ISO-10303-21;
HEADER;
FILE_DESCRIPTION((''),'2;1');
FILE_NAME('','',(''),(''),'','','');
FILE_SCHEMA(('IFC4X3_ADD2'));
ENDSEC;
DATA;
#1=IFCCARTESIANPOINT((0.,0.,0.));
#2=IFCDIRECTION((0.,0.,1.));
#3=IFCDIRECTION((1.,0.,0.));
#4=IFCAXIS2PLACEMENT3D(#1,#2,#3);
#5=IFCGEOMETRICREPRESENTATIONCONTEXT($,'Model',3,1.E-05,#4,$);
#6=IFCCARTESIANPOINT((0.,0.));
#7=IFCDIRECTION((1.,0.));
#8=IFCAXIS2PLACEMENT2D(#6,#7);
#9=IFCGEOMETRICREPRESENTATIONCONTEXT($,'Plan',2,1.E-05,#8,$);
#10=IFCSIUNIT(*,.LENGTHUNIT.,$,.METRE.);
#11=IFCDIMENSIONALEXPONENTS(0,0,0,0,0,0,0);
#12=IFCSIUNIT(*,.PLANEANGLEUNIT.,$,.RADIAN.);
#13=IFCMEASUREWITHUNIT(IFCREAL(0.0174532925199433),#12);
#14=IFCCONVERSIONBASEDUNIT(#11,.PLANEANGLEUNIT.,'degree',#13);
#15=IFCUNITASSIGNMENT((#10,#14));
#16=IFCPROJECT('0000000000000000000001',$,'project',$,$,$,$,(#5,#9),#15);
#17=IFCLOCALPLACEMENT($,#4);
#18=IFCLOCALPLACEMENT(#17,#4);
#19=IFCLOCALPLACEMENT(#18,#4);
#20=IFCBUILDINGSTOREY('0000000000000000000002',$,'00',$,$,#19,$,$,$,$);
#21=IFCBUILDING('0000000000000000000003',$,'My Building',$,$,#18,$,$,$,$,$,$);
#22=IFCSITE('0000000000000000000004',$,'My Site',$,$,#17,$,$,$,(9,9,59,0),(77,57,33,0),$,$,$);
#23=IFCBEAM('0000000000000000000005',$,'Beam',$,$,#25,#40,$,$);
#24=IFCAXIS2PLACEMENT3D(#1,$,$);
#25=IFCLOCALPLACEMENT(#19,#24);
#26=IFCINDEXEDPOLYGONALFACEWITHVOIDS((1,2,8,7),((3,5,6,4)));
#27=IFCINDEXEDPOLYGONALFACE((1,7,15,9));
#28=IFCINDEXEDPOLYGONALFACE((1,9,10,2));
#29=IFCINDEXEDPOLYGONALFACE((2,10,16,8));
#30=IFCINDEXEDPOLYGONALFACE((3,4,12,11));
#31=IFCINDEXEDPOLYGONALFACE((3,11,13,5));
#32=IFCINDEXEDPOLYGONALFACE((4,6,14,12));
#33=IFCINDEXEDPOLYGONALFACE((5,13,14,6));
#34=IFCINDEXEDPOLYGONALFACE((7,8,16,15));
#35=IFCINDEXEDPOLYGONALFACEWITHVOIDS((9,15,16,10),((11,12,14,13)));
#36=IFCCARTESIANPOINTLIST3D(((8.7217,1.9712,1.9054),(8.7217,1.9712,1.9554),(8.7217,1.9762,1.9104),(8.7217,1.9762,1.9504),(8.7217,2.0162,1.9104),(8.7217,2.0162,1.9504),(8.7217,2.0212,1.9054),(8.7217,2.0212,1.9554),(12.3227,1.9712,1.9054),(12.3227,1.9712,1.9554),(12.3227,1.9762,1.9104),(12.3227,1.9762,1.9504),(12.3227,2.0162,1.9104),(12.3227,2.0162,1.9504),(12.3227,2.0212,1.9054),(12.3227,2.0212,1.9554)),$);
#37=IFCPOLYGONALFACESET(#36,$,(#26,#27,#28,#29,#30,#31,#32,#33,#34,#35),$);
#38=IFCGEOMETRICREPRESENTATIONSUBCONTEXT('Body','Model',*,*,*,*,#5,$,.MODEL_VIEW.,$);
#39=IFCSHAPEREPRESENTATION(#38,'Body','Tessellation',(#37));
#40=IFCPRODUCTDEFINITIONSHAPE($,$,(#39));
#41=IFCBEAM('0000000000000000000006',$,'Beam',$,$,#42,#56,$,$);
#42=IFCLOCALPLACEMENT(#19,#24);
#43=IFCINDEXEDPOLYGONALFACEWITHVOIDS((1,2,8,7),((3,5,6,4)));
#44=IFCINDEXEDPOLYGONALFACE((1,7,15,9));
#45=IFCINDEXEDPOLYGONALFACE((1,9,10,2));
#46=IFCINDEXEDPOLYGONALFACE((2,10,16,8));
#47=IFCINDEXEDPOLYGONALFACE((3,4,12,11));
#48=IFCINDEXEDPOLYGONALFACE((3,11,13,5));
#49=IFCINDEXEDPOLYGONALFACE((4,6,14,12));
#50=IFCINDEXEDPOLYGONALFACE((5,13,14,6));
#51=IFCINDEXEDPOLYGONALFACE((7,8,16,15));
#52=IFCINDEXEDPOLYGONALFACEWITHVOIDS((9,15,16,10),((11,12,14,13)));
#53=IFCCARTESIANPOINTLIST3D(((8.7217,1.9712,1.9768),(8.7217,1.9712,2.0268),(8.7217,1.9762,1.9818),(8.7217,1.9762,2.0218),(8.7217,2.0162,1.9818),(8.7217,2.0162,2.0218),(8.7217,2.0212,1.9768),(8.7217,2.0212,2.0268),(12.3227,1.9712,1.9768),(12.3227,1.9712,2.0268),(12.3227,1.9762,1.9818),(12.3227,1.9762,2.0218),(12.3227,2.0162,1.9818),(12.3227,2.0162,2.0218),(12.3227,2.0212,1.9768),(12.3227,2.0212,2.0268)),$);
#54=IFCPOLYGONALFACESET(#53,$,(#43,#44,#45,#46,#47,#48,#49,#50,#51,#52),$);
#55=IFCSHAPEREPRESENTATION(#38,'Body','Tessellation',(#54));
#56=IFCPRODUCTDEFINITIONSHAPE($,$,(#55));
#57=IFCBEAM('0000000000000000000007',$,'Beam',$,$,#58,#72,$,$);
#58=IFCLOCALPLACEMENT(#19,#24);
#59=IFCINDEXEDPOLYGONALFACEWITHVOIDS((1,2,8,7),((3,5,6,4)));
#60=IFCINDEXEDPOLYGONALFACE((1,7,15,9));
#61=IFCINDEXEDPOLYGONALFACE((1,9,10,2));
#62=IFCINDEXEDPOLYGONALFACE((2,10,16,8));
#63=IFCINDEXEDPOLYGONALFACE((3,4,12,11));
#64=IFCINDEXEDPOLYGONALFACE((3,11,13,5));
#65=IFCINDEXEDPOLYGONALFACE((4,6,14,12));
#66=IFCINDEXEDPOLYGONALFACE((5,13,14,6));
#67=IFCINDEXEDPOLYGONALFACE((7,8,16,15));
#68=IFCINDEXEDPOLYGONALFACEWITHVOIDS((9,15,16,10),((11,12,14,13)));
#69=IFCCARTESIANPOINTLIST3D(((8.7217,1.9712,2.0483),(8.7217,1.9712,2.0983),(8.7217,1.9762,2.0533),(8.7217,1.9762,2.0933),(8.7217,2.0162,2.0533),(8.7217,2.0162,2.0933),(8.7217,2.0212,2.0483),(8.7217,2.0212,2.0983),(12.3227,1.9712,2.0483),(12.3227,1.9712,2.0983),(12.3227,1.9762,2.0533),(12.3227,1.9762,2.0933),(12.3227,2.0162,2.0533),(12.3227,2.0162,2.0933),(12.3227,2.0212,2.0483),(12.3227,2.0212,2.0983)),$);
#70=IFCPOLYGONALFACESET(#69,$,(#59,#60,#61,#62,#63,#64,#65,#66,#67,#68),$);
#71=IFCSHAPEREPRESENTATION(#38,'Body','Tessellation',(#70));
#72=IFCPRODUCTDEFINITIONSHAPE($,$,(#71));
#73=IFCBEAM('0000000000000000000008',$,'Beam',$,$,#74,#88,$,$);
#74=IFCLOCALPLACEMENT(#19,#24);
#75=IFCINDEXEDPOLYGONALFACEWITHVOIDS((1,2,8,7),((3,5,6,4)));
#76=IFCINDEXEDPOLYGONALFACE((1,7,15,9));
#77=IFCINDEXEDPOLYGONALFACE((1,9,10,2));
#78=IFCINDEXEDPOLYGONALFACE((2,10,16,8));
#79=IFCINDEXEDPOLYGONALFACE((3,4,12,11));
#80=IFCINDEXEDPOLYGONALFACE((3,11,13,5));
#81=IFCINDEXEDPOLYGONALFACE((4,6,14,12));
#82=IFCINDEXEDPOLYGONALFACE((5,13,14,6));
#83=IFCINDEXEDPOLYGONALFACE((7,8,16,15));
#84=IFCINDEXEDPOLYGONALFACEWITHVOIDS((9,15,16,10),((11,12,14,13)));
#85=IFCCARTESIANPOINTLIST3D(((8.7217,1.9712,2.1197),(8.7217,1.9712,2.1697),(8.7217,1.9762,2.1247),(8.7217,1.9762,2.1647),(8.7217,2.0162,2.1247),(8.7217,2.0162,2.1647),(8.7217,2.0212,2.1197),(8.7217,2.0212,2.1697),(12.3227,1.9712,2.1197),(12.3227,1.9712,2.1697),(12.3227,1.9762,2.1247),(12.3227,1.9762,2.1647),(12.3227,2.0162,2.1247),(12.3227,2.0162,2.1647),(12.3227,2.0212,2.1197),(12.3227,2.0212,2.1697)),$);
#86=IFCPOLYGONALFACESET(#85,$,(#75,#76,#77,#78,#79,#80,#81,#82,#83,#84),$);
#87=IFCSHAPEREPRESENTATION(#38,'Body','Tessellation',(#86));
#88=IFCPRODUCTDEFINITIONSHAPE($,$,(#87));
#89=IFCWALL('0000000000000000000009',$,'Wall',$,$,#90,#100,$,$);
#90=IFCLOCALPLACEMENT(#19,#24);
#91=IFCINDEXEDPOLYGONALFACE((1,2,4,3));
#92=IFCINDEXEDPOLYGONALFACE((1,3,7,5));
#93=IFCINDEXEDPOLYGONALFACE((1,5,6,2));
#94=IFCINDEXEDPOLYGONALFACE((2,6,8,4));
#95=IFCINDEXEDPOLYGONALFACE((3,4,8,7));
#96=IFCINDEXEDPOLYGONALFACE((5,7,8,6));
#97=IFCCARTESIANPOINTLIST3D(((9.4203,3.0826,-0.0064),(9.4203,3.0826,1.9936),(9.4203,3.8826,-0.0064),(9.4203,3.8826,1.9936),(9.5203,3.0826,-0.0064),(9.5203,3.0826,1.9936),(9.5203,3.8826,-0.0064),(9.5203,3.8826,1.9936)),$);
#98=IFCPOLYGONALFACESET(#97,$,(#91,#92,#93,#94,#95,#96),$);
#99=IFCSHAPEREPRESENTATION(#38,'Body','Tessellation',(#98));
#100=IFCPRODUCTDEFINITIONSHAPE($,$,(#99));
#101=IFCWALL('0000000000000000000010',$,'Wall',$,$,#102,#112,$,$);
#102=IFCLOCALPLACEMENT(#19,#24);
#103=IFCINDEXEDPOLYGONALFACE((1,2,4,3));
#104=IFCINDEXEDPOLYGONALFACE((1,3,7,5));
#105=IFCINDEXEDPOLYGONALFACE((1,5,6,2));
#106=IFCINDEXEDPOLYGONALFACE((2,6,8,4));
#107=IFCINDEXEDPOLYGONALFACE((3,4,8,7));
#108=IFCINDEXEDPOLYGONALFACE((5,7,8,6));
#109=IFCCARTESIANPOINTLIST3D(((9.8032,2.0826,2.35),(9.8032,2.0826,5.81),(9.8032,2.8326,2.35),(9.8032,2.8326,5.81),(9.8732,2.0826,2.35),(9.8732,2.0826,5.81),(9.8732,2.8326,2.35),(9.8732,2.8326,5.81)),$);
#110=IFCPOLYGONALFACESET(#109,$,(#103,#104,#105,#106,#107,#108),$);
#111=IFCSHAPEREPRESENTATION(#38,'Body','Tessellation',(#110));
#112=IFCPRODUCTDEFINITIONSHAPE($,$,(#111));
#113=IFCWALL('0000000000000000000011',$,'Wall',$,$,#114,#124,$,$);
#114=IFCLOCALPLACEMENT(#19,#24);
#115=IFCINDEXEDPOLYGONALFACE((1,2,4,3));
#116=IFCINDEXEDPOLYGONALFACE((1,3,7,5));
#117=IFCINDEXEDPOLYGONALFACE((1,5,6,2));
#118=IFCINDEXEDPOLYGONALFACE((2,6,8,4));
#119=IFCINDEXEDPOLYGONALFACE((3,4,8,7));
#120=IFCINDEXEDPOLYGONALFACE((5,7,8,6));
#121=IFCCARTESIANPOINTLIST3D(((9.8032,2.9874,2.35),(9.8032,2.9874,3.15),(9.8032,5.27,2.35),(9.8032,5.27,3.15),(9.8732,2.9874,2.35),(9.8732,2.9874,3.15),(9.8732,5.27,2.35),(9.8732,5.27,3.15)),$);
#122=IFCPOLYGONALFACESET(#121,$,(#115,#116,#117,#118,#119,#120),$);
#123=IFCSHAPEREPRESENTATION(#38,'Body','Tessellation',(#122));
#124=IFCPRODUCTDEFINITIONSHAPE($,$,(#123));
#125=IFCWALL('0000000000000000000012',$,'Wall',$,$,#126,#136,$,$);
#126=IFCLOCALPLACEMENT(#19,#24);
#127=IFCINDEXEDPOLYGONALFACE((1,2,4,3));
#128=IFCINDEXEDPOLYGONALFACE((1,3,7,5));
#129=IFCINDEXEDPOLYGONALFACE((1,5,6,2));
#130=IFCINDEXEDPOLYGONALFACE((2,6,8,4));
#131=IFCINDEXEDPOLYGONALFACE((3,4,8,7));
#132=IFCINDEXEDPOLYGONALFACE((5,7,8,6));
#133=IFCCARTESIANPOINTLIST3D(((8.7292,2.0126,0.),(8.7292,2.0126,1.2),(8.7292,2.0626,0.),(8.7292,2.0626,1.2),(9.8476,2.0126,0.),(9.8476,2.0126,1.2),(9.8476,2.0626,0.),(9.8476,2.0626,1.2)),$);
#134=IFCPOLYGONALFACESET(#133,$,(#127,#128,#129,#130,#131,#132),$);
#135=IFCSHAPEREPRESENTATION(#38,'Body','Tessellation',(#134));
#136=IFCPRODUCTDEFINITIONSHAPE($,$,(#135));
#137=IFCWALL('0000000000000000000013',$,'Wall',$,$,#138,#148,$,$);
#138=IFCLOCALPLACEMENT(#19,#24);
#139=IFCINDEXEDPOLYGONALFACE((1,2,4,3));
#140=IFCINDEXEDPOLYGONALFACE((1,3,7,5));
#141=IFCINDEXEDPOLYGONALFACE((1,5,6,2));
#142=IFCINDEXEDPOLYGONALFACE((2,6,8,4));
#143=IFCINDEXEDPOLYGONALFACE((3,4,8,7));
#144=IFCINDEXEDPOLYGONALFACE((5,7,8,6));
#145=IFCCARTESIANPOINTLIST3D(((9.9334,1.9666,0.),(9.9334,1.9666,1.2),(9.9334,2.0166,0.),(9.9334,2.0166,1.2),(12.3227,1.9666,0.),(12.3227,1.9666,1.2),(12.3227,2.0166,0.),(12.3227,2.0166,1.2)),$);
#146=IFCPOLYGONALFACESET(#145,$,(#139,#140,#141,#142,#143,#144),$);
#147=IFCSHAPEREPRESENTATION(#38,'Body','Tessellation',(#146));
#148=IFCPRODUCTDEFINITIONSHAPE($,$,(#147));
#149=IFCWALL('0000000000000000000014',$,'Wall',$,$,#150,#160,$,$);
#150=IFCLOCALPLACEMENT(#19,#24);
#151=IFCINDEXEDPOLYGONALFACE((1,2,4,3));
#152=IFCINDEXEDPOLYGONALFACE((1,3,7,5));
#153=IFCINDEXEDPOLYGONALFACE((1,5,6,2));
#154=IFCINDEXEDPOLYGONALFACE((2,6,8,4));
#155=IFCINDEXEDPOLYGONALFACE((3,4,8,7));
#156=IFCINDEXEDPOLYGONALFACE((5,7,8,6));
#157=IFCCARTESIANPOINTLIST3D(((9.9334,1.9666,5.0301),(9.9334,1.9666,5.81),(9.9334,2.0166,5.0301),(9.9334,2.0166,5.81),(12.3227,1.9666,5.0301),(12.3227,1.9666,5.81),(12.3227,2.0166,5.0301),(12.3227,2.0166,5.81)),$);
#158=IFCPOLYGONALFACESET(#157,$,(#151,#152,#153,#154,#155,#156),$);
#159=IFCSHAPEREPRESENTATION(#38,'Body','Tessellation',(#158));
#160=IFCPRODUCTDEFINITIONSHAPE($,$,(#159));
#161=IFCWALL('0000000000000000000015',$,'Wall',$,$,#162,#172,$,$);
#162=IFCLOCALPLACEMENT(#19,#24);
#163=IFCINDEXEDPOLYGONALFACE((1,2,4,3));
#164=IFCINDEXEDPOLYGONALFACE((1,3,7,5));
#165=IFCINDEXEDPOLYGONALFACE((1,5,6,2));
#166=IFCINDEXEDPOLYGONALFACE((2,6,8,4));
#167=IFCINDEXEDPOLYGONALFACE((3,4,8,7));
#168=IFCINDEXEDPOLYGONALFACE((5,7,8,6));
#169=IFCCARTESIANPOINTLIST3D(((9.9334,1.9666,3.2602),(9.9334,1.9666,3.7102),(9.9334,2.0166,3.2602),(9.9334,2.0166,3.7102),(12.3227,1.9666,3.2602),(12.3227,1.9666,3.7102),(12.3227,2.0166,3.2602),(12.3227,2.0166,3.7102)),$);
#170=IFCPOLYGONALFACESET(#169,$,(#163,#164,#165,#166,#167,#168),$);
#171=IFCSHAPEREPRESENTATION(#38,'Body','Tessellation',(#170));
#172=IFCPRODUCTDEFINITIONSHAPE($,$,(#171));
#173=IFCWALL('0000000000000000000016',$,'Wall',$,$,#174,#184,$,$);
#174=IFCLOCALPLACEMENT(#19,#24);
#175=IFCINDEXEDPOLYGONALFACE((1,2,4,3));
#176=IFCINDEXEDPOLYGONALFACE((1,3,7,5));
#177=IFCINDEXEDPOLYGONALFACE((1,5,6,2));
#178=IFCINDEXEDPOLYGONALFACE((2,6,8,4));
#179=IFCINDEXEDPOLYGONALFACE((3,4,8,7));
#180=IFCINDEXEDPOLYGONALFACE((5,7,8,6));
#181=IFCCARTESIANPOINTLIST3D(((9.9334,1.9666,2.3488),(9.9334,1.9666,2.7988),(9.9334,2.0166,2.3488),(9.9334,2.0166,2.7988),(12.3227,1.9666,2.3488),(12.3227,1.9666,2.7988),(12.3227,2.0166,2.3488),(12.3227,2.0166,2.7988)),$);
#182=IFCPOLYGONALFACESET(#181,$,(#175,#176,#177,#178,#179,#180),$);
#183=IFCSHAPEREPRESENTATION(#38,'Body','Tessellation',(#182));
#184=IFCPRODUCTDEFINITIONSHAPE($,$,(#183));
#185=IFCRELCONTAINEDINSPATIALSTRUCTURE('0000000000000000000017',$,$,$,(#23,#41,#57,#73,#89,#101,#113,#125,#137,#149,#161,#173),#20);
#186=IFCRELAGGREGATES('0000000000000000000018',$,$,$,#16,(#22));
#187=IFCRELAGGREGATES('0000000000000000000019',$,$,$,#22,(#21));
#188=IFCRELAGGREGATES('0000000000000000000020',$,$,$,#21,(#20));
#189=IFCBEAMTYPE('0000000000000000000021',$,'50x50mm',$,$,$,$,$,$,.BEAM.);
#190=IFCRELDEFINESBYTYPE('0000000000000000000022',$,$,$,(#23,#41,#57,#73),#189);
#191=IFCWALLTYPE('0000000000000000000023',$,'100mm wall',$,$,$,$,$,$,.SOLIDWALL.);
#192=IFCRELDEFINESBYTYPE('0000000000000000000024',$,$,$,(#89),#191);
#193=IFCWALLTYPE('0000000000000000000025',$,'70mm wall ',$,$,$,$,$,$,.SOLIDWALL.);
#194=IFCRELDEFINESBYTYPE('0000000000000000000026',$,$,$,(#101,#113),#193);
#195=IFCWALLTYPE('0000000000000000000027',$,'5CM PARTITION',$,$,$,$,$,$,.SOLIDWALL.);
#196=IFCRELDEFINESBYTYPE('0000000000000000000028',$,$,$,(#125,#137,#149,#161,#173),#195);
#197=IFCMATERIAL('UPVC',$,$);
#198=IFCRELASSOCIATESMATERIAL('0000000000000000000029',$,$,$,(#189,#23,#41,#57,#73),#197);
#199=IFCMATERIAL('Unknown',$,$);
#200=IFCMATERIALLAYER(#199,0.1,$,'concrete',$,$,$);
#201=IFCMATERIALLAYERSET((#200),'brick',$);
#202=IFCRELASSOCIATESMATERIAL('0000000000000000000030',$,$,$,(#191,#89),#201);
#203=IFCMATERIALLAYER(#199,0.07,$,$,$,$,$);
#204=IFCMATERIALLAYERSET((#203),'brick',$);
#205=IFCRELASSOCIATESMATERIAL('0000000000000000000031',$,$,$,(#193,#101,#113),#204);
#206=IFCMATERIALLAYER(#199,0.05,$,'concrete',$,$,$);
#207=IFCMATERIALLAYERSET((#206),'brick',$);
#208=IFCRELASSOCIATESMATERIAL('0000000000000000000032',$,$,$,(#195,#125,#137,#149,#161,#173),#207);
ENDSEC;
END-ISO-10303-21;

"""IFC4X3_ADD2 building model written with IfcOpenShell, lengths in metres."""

from ifc_helpers import new_model, entity, si_unit, converted_unit, frame, origin_with_axes, origin_2d_with_axis, place, context, subcontext, project, spatial, line, indexed_curve, hollow_rectangle, outline, extrude, material, layer, layer_set, layer_usage, material_profile, profile_set, profile_usage, type_object, element, save


model = new_model("IFC4X3_ADD2")

# Units and contexts
model_context = context("Model", 3, precision=1e-05, world=origin_with_axes())
plan_context = context("Plan", 2, precision=1e-05, world=origin_2d_with_axis())
body_context = subcontext(model_context, "Body", "Model", "MODEL_VIEW")
ifc_project = project(units=[si_unit("LENGTHUNIT", "METRE"), converted_unit("PLANEANGLEUNIT", "degree", entity("IfcReal", 0.0174532925199433), si_unit("PLANEANGLEUNIT", "RADIAN"), dimensions=[0, 0, 0, 0, 0, 0, 0])], contexts=[model_context, plan_context])

# Site, building, storey
site_placement = place(None, origin_with_axes())
site = spatial("IfcSite", under=ifc_project, at=site_placement, Name="My Site", RefLatitude=(9, 9, 59, 0), RefLongitude=(77, 57, 33, 0))
building_placement = place(site_placement, origin_with_axes())
building = spatial("IfcBuilding", under=site, at=building_placement, Name="My Building")
storey_placement = place(building_placement, origin_with_axes())
storey = spatial("IfcBuildingStorey", under=building, at=storey_placement, Name="00")

# Shared definitions
ifc_material_1 = material(Name="UPVC")

# Beams
ifc_material_profile_1 = material_profile(ifc_material_1, hollow_rectangle(XDim=0.05, YDim=0.05, WallThickness=0.005))
ifc_profile_set_1 = profile_set([ifc_material_profile_1])
beam_type = type_object("IfcBeamType", Name="50x50mm", PredefinedType="BEAM", material=ifc_profile_set_1)
ifc_profile_usage_1 = profile_usage(ifc_profile_set_1, cardinal=5)
beam_1_placement = place(storey_placement, frame((8.7217, 1.9962, 1.9304), z_axis=(1.0, 0.0, 0.000001), x_axis=(0.0, 1.0, 0.0)))
element("IfcBeam", 1, at=beam_1_placement, inside=storey, type_object=beam_type, material=ifc_profile_usage_1, Name="Beam", context=body_context, shape_type="SweptSolid", body=[
    extrude(hollow_rectangle(XDim=0.05, YDim=0.05, WallThickness=0.005), origin_with_axes(), (0.0, 0.0, 1.0), 3.601),
])
ifc_profile_usage_2 = profile_usage(ifc_profile_set_1, cardinal=5)
beam_2_placement = place(storey_placement, frame((8.7217, 1.9962, 2.0018), z_axis=(1.0, 0.0, 0.000001), x_axis=(0.0, 1.0, 0.0)))
element("IfcBeam", 2, at=beam_2_placement, inside=storey, type_object=beam_type, material=ifc_profile_usage_2, Name="Beam", context=body_context, shape_type="SweptSolid", body=[
    extrude(hollow_rectangle(XDim=0.05, YDim=0.05, WallThickness=0.005), origin_with_axes(), (0.0, 0.0, 1.0), 3.601),
])
ifc_profile_usage_3 = profile_usage(ifc_profile_set_1, cardinal=5)
beam_3_placement = place(storey_placement, frame((8.7217, 1.9962, 2.0733), z_axis=(1.0, 0.0, 0.000001), x_axis=(0.0, 1.0, 0.0)))
element("IfcBeam", 3, at=beam_3_placement, inside=storey, type_object=beam_type, material=ifc_profile_usage_3, Name="Beam", context=body_context, shape_type="SweptSolid", body=[
    extrude(hollow_rectangle(XDim=0.05, YDim=0.05, WallThickness=0.005), origin_with_axes(), (0.0, 0.0, 1.0), 3.601),
])
ifc_profile_usage_4 = profile_usage(ifc_profile_set_1, cardinal=5)
beam_4_placement = place(storey_placement, frame((8.7217, 1.9962, 2.1447), z_axis=(1.0, 0.0, 0.000001), x_axis=(0.0, 1.0, 0.0)))
element("IfcBeam", 4, at=beam_4_placement, inside=storey, type_object=beam_type, material=ifc_profile_usage_4, Name="Beam", context=body_context, shape_type="SweptSolid", body=[
    extrude(hollow_rectangle(XDim=0.05, YDim=0.05, WallThickness=0.005), origin_with_axes(), (0.0, 0.0, 1.0), 3.601),
])

# Walls
ifc_material_2 = material(Name="Unknown")
ifc_layer_1 = layer(ifc_material_2, 0.1, Name="concrete")
ifc_layer_set_1 = layer_set([ifc_layer_1], Name="brick")
ifc_layer_usage_1 = layer_usage(ifc_layer_set_1, "AXIS2", "POSITIVE", 0.0)
wall_type_1 = type_object("IfcWallType", Name="100mm wall", PredefinedType="SOLIDWALL", material=ifc_layer_set_1)
wall_1_placement = place(storey_placement, frame((9.5203, 3.0826, -0.0064), z_axis=(0.0, 0.0, 1.0), x_axis=(0.0, 1.0, 0.0)))
element("IfcWall", 5, at=wall_1_placement, inside=storey, type_object=wall_type_1, material=ifc_layer_usage_1, Name="Wall", context=body_context, shape_type="SweptSolid", body=[
    extrude(outline(indexed_curve([(0.0, 0.0), (0.0, 0.1), (0.8, 0.1), (0.8, 0.0)], segments=[line(1, 2, 3, 4, 1)])), origin_with_axes(), (0.0, 0.0, 1.0), 2.0),
])
ifc_layer_2 = layer(ifc_material_2, 0.07)
ifc_layer_set_2 = layer_set([ifc_layer_2], Name="brick")
ifc_layer_usage_2 = layer_usage(ifc_layer_set_2, "AXIS2", "POSITIVE", 0.0)
wall_type_2 = type_object("IfcWallType", Name="70mm wall ", PredefinedType="SOLIDWALL", material=ifc_layer_set_2)
wall_2_placement = place(storey_placement, frame((9.8732, 2.0826, 2.35), z_axis=(0.0, 0.0, 1.0), x_axis=(0.0, 1.0, 0.0)))
element("IfcWall", 6, at=wall_2_placement, inside=storey, type_object=wall_type_2, material=ifc_layer_usage_2, Name="Wall", context=body_context, shape_type="SweptSolid", body=[
    extrude(outline(indexed_curve([(0.0, 0.0), (0.0, 0.07), (0.75, 0.07), (0.75, 0.0)], segments=[line(1, 2, 3, 4, 1)])), origin_with_axes(), (0.0, 0.0, 1.0), 3.46),
])
ifc_layer_usage_3 = layer_usage(ifc_layer_set_2, "AXIS2", "POSITIVE", 0.0)
wall_3_placement = place(storey_placement, frame((9.8732, 2.9874, 2.35), z_axis=(0.0, 0.0, 1.0), x_axis=(0.0, 1.0, 0.0)))
element("IfcWall", 7, at=wall_3_placement, inside=storey, type_object=wall_type_2, material=ifc_layer_usage_3, Name="Wall", context=body_context, shape_type="SweptSolid", body=[
    extrude(outline(indexed_curve([(0.0, 0.0), (0.0, 0.07), (2.2826, 0.07), (2.2826, 0.0)], segments=[line(1, 2, 3, 4, 1)])), origin_with_axes(), (0.0, 0.0, 1.0), 0.8),
])
ifc_layer_3 = layer(ifc_material_2, 0.05, Name="concrete")
ifc_layer_set_3 = layer_set([ifc_layer_3], Name="brick")
ifc_layer_usage_4 = layer_usage(ifc_layer_set_3, "AXIS2", "POSITIVE", 0.0)
wall_type_3 = type_object("IfcWallType", Name="5CM PARTITION", PredefinedType="SOLIDWALL", material=ifc_layer_set_3)
wall_4_placement = place(storey_placement, frame((8.7292, 2.0126, 0.0), z_axis=(0.0, 0.0, 1.0), x_axis=(1.0, 0.0, 0.0)))
element("IfcWall", 8, at=wall_4_placement, inside=storey, type_object=wall_type_3, material=ifc_layer_usage_4, Name="Wall", context=body_context, shape_type="SweptSolid", body=[
    extrude(outline(indexed_curve([(0.0, 0.0), (0.0, 0.05), (1.1184, 0.05), (1.1184, 0.0)], segments=[line(1, 2, 3, 4, 1)])), origin_with_axes(), (0.0, 0.0, 1.0), 1.2),
])
ifc_layer_usage_5 = layer_usage(ifc_layer_set_3, "AXIS2", "POSITIVE", 0.0)
wall_5_placement = place(storey_placement, frame((9.9334, 1.9666, 0.0), z_axis=(0.0, 0.0, 1.0), x_axis=(1.0, 0.0, 0.0)))
element("IfcWall", 9, at=wall_5_placement, inside=storey, type_object=wall_type_3, material=ifc_layer_usage_5, Name="Wall", context=body_context, shape_type="SweptSolid", body=[
    extrude(outline(indexed_curve([(0.0, 0.0), (0.0, 0.05), (2.3893, 0.05), (2.3893, 0.0)], segments=[line(1, 2, 3, 4, 1)])), origin_with_axes(), (0.0, 0.0, 1.0), 1.2),
])
ifc_layer_usage_6 = layer_usage(ifc_layer_set_3, "AXIS2", "POSITIVE", 0.0)
wall_6_placement = place(storey_placement, frame((9.9334, 1.9666, 5.0301), z_axis=(0.0, 0.0, 1.0), x_axis=(1.0, 0.0, 0.0)))
element("IfcWall", 10, at=wall_6_placement, inside=storey, type_object=wall_type_3, material=ifc_layer_usage_6, Name="Wall", context=body_context, shape_type="SweptSolid", body=[
    extrude(outline(indexed_curve([(0.0, 0.0), (0.0, 0.05), (2.3893, 0.05), (2.3893, 0.0)], segments=[line(1, 2, 3, 4, 1)])), origin_with_axes(), (0.0, 0.0, 1.0), 0.7799),
])
ifc_layer_usage_7 = layer_usage(ifc_layer_set_3, "AXIS2", "POSITIVE", 0.0)
wall_7_placement = place(storey_placement, frame((9.9334, 1.9666, 3.2602), z_axis=(0.0, 0.0, 1.0), x_axis=(1.0, 0.0, 0.0)))
element("IfcWall", 11, at=wall_7_placement, inside=storey, type_object=wall_type_3, material=ifc_layer_usage_7, Name="Wall", context=body_context, shape_type="SweptSolid", body=[
    extrude(outline(indexed_curve([(0.0, 0.0), (0.0, 0.05), (2.3893, 0.05), (2.3893, 0.0)], segments=[line(1, 2, 3, 4, 1)])), origin_with_axes(), (0.0, 0.0, 1.0), 0.45),
])
ifc_layer_usage_8 = layer_usage(ifc_layer_set_3, "AXIS2", "POSITIVE", 0.0)
wall_8_placement = place(storey_placement, frame((9.9334, 1.9666, 2.3488), z_axis=(0.0, 0.0, 1.0), x_axis=(1.0, 0.0, 0.0)))
element("IfcWall", 12, at=wall_8_placement, inside=storey, type_object=wall_type_3, material=ifc_layer_usage_8, Name="Wall", context=body_context, shape_type="SweptSolid", body=[
    extrude(outline(indexed_curve([(0.0, 0.0), (0.0, 0.05), (2.3893, 0.05), (2.3893, 0.0)], segments=[line(1, 2, 3, 4, 1)])), origin_with_axes(), (0.0, 0.0, 1.0), 0.45),
])

save(model, "model.ifc")
